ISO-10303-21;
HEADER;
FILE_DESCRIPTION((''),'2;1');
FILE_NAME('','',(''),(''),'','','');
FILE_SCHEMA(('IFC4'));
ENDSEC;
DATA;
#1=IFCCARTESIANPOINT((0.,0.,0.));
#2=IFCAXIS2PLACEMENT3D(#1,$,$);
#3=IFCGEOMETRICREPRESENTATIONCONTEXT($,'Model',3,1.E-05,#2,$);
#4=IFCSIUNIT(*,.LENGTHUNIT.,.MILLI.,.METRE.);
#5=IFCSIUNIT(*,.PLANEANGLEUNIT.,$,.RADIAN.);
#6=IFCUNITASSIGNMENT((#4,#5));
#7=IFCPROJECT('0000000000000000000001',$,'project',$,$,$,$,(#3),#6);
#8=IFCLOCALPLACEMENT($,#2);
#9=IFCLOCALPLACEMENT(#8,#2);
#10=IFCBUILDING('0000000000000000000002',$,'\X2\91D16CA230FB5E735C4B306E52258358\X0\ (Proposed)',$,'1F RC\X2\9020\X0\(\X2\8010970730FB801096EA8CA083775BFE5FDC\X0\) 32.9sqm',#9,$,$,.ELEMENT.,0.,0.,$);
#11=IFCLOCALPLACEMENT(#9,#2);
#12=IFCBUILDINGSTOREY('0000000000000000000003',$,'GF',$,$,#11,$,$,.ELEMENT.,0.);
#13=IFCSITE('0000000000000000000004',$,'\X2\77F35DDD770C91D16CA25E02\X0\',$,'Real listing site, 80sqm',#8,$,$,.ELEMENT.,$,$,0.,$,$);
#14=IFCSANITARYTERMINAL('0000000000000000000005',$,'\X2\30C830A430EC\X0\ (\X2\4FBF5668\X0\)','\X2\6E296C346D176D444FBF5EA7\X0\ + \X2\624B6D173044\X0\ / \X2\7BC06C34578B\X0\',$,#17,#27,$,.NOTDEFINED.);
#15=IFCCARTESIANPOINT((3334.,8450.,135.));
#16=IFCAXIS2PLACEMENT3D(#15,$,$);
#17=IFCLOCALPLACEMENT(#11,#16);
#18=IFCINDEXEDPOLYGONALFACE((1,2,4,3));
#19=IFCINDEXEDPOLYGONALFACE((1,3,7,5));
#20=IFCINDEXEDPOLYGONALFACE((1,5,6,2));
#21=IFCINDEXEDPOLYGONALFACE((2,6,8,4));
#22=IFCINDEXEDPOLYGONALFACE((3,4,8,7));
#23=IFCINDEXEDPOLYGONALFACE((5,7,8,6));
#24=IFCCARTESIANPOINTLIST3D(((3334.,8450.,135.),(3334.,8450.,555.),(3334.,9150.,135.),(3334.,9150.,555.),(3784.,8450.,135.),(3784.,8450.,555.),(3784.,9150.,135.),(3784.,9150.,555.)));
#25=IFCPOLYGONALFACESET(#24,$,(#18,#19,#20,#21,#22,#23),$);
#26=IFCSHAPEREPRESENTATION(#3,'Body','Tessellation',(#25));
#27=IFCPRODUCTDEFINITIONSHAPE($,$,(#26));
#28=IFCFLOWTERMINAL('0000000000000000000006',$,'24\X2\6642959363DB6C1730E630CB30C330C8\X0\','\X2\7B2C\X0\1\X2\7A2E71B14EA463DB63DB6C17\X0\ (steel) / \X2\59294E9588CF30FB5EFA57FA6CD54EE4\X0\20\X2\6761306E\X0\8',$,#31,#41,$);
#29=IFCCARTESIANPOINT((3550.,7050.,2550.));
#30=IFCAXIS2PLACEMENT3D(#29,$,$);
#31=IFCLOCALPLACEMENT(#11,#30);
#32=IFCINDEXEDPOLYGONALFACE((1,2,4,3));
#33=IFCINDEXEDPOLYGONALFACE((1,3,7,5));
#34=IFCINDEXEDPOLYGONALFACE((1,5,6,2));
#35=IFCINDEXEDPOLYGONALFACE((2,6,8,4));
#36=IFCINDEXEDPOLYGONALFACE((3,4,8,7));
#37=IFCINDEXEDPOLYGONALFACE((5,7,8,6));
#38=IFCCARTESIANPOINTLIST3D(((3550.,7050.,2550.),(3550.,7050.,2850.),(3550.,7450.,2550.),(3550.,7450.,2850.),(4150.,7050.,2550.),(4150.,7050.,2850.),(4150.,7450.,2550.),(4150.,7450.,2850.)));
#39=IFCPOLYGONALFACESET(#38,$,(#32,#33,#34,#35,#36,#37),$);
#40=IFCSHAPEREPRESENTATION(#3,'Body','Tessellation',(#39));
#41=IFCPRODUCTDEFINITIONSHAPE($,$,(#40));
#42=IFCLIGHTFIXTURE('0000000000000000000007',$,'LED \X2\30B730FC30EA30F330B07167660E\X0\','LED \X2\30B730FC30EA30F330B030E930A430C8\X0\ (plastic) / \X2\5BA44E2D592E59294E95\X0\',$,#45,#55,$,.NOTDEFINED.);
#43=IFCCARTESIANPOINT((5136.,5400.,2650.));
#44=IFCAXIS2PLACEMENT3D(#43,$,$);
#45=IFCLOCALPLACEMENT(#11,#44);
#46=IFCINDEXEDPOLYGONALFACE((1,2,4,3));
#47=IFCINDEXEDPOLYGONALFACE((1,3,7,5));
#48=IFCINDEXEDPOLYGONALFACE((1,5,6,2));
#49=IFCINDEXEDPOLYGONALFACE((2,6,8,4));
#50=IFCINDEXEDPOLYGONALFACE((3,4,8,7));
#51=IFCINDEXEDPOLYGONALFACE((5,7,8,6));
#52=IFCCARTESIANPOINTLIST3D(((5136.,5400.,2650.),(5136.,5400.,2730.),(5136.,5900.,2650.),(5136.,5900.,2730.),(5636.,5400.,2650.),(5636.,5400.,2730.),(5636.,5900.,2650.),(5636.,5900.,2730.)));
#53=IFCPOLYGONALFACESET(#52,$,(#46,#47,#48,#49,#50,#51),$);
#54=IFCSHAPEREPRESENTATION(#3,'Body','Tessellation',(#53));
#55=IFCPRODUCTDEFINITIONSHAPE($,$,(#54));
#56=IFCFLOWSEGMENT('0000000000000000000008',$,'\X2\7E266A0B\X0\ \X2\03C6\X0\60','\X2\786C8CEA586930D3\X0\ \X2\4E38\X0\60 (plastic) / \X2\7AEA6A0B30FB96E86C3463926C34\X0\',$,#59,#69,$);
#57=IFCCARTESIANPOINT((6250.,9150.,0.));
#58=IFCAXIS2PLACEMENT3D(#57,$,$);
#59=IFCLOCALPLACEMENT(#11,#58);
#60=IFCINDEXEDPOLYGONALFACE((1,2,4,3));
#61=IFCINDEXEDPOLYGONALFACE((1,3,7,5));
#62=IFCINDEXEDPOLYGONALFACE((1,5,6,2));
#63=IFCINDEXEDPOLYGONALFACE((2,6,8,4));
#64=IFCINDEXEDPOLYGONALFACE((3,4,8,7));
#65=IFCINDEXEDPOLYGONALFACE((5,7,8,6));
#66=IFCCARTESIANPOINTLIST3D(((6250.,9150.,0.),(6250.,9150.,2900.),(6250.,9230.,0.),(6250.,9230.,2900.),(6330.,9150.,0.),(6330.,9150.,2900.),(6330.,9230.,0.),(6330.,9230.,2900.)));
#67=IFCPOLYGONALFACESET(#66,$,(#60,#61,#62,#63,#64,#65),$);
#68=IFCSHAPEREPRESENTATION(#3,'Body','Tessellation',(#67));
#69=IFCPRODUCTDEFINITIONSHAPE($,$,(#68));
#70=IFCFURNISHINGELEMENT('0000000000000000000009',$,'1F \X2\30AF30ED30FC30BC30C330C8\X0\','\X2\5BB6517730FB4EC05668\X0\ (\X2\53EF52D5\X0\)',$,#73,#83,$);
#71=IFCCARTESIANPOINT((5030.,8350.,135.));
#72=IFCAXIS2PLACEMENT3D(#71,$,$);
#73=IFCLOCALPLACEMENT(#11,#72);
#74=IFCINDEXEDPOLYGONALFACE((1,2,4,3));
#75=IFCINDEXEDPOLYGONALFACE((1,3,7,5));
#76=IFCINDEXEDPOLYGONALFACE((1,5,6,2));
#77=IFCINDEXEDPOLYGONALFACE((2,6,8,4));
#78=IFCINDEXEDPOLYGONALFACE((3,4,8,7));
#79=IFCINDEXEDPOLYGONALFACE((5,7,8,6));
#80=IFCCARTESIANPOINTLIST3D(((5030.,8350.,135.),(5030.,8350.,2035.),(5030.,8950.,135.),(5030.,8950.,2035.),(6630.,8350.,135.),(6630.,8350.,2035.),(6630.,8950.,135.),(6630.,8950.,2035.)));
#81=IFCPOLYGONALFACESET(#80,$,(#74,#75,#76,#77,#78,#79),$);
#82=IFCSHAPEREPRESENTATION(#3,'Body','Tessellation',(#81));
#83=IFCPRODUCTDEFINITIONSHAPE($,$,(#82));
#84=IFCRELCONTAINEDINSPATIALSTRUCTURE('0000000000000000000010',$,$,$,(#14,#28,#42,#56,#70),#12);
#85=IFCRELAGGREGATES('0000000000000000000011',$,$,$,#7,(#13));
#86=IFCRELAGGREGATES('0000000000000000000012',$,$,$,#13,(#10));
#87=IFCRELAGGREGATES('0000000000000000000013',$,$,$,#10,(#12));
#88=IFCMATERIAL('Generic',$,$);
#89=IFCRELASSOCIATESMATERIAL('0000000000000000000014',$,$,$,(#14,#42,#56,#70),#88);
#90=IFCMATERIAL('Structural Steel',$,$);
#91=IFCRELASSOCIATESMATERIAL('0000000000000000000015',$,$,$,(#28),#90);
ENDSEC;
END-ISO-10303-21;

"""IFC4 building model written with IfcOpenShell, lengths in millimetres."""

from ifc_helpers import new_model, si_unit, frame, frame_2d, origin, place, context, project, spatial, rectangle, extrude, material, element, save


model = new_model("IFC4")

# Units and contexts
model_context = context("Model", 3, precision=1e-05, world=origin())
ifc_project = project(units=[si_unit("LENGTHUNIT", "METRE", prefix="MILLI"), si_unit("PLANEANGLEUNIT", "RADIAN")], contexts=[model_context])

# Site, building, storey
site_placement = place(None, origin())
site = spatial("IfcSite", under=ifc_project, at=site_placement, Name="石川県金沢市", ObjectType="Real listing site, 80sqm", CompositionType="ELEMENT", RefElevation=0.0)
building_placement = place(site_placement, origin())
building = spatial("IfcBuilding", under=site, at=building_placement, Name="金沢・平屋の別荘 (Proposed)", ObjectType="1F RC造(耐震・耐雪負荷対応) 32.9sqm", CompositionType="ELEMENT", ElevationOfRefHeight=0.0, ElevationOfTerrain=0.0)
storey_placement = place(building_placement, origin())
storey = spatial("IfcBuildingStorey", under=building, at=storey_placement, Name="GF", CompositionType="ELEMENT", Elevation=0.0)

# Shared definitions
ifc_material_1 = material(Name="Generic")

# Sanitary terminal
sanitary_terminal_1_placement = place(storey_placement, frame((3334.0, 8450.0, 135.0)))
element("IfcSanitaryTerminal", 1, at=sanitary_terminal_1_placement, inside=storey, material=ifc_material_1, Name="トイレ (便器)", Description="温水洗浄便座 + 手洗い / 節水型", PredefinedType="NOTDEFINED", context=model_context, shape_type="SweptSolid", body=[
    extrude(rectangle(XDim=450.0, YDim=700.0, at=frame_2d((225.0, 350.0))), frame((3334.0, 8450.0, 135.0)), (0.0, 0.0, 1.0), 420.0),
])

# Flow terminal
ifc_material_2 = material(Name="Structural Steel")
flow_terminal_placement = place(storey_placement, frame((3550.0, 7050.0, 2550.0)))
element("IfcFlowTerminal", 2, at=flow_terminal_placement, inside=storey, material=ifc_material_2, Name="24時間換気ユニット", Description="第1種熱交換換気 (steel) / 天井裏・建基法令20条の8", context=model_context, shape_type="SweptSolid", body=[
    extrude(rectangle(XDim=600.0, YDim=400.0, at=frame_2d((300.0, 200.0))), frame((3550.0, 7050.0, 2550.0)), (0.0, 0.0, 1.0), 300.0),
])

# Light fixture
light_fixture_placement = place(storey_placement, frame((5136.0, 5400.0, 2650.0)))
element("IfcLightFixture", 3, at=light_fixture_placement, inside=storey, material=ifc_material_1, Name="LED シーリング照明", Description="LED シーリングライト (plastic) / 室中央天井", PredefinedType="NOTDEFINED", context=model_context, shape_type="SweptSolid", body=[
    extrude(rectangle(XDim=500.0, YDim=500.0, at=frame_2d((250.0, 250.0))), frame((5136.0, 5400.0, 2650.0)), (0.0, 0.0, 1.0), 80.0),
])

# Flow segment
flow_segment_placement = place(storey_placement, frame((6250.0, 9150.0, 0.0)))
element("IfcFlowSegment", 4, at=flow_segment_placement, inside=storey, material=ifc_material_1, Name="縦樋 φ60", Description="硬質塩ビ 丸60 (plastic) / 竪樋・雨水排水", context=model_context, shape_type="SweptSolid", body=[
    extrude(rectangle(XDim=80.0, YDim=80.0, at=frame_2d((40.0, 40.0))), frame((6250.0, 9150.0, 0.0)), (0.0, 0.0, 1.0), 2900.0),
])

# Furnishing element
furnishing_placement = place(storey_placement, frame((5030.0, 8350.0, 135.0)))
element("IfcFurnishingElement", 5, at=furnishing_placement, inside=storey, material=ifc_material_1, Name="1F クローゼット", Description="家具・什器 (可動)", context=model_context, shape_type="SweptSolid", body=[
    extrude(rectangle(XDim=1600.0, YDim=600.0, at=frame_2d((800.0, 300.0))), frame((5030.0, 8350.0, 135.0)), (0.0, 0.0, 1.0), 1900.0),
])

save(model, "model.ifc")
